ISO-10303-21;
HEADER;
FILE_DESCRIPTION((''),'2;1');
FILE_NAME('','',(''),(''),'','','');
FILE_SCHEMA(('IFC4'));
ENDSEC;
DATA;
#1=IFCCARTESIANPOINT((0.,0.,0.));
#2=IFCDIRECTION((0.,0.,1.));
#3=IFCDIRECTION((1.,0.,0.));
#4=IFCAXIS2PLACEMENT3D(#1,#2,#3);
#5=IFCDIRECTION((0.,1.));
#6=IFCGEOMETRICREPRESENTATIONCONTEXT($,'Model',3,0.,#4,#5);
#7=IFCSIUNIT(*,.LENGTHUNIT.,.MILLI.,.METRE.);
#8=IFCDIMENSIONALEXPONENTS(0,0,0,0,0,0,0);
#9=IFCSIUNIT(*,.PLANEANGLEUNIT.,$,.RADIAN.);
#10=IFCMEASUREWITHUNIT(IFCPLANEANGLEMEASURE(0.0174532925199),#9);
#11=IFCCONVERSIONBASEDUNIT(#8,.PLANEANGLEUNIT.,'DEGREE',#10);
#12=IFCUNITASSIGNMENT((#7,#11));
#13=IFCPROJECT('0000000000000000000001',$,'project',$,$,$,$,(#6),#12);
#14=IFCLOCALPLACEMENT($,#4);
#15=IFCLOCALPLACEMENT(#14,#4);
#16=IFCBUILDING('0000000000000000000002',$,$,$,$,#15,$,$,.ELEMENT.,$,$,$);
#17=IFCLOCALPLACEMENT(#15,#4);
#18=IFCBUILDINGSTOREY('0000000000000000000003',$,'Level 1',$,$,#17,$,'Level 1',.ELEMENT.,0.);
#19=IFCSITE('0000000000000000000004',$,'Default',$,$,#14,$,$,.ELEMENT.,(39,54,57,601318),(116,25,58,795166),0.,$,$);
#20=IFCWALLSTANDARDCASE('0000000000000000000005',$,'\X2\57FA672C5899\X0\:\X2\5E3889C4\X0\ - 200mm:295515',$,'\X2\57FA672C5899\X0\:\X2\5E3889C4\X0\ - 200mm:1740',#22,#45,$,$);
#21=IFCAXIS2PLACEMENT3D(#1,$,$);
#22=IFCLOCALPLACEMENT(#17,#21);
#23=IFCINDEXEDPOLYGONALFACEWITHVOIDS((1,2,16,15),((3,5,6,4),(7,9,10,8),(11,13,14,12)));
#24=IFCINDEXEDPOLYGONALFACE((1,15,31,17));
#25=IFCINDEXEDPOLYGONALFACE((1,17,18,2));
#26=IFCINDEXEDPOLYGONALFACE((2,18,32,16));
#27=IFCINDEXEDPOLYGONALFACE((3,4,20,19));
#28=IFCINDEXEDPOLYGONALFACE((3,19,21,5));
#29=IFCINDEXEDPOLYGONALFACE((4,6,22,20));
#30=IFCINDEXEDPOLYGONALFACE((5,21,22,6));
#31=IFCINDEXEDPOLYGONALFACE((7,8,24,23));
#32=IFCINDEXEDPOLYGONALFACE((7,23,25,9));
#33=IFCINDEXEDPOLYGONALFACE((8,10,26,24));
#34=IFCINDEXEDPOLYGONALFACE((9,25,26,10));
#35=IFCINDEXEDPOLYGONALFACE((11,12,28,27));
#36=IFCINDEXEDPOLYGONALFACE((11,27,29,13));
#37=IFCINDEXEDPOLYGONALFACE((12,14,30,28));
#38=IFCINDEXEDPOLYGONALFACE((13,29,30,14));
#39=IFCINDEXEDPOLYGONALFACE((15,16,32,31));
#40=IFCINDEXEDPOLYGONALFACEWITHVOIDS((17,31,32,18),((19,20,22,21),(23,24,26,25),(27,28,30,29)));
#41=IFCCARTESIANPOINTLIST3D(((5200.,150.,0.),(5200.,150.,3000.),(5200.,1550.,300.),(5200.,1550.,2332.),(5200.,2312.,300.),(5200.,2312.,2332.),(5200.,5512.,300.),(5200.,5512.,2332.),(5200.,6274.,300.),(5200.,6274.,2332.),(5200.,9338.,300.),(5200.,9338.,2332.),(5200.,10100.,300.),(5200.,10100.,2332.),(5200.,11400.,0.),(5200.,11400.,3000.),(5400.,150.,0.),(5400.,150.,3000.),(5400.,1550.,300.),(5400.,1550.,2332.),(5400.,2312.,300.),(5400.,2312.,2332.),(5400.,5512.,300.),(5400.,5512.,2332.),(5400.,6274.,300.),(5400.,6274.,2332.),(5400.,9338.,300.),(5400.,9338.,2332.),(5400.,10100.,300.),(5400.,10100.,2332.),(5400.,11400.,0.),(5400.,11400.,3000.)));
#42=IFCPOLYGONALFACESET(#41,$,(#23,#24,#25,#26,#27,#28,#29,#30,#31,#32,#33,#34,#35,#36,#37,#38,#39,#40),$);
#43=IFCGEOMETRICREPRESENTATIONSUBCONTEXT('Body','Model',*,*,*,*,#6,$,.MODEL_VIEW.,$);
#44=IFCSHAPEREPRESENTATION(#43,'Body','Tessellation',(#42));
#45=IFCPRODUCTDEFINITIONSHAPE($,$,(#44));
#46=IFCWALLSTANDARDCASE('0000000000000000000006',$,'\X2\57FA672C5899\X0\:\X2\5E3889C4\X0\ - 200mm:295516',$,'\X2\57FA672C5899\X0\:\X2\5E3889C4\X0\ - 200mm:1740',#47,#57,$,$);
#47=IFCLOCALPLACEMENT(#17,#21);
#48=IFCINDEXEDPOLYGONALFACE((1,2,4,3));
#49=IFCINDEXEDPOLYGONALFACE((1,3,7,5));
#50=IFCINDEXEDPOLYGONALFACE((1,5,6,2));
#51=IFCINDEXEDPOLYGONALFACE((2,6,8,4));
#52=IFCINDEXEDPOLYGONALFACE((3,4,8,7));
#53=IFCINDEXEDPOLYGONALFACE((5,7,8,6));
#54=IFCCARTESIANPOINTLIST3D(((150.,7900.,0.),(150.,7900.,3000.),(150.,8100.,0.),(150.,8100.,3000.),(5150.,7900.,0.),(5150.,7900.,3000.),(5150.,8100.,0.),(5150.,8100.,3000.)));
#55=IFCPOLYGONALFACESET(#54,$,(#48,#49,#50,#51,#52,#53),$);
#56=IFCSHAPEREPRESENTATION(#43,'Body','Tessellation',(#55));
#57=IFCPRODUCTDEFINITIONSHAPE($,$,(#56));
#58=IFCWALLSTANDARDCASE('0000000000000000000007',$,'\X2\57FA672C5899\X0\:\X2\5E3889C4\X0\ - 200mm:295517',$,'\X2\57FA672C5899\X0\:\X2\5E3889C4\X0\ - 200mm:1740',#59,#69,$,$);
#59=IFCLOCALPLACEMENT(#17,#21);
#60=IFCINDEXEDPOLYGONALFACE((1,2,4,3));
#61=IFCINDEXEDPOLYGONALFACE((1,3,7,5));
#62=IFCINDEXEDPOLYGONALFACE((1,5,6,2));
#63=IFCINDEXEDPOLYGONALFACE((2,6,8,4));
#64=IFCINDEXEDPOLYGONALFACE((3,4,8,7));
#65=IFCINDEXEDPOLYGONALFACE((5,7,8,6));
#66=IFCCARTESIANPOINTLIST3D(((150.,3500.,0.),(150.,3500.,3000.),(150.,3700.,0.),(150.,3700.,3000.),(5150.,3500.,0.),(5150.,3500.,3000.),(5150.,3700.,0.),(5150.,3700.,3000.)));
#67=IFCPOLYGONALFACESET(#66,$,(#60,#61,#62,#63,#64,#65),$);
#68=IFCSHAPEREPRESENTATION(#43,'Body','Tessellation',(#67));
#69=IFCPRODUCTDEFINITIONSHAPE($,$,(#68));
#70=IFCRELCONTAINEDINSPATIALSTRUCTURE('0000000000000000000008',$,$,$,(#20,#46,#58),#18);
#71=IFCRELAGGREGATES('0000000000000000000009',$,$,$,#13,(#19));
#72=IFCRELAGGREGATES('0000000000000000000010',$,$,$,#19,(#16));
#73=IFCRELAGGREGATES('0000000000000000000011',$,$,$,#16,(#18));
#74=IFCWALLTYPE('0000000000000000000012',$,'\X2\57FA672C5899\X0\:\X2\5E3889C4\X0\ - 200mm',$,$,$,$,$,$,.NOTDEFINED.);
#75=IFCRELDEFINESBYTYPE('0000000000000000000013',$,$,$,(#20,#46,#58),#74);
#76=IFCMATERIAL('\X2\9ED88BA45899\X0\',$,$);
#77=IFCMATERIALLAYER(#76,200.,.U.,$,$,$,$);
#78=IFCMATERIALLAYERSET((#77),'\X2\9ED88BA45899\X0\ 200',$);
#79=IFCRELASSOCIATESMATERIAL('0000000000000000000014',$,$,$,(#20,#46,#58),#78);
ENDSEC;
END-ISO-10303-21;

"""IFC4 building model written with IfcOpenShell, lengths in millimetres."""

from ifc_helpers import new_model, entity, si_unit, converted_unit, direction, frame, origin_with_axes, place, context, subcontext, project, spatial, polyline, outline, extrude, material, layer, layer_set, layer_usage, type_object, element, save


model = new_model("IFC4")

# Units and contexts
model_context = context("Model", 3, precision=0.0, world=origin_with_axes(), true_north=direction((0.0, 1.0)))
body_context = subcontext(model_context, "Body", "Model", "MODEL_VIEW")
ifc_project = project(units=[si_unit("LENGTHUNIT", "METRE", prefix="MILLI"), converted_unit("PLANEANGLEUNIT", "DEGREE", entity("IfcPlaneAngleMeasure", 0.0174532925199), si_unit("PLANEANGLEUNIT", "RADIAN"), dimensions=[0, 0, 0, 0, 0, 0, 0])], contexts=[model_context])

# Site, building, storey
site_placement = place(None, origin_with_axes())
site = spatial("IfcSite", under=ifc_project, at=site_placement, Name="Default", CompositionType="ELEMENT", RefLatitude=(39, 54, 57, 601318), RefLongitude=(116, 25, 58, 795166), RefElevation=0.0)
building_placement = place(site_placement, origin_with_axes())
building = spatial("IfcBuilding", under=site, at=building_placement, CompositionType="ELEMENT")
storey_placement = place(building_placement, origin_with_axes())
storey = spatial("IfcBuildingStorey", under=building, at=storey_placement, Name="Level 1", LongName="Level 1", CompositionType="ELEMENT", Elevation=0.0)

# Shared definitions
ifc_material_1 = material(Name="默认墙")
ifc_layer_1 = layer(ifc_material_1, 200.0, ventilated="UNKNOWN")
ifc_layer_set_1 = layer_set([ifc_layer_1], Name="默认墙 200")
wall_type = type_object("IfcWallType", Name="基本墙:常规 - 200mm", PredefinedType="NOTDEFINED")

# Wall, openings
ifc_layer_usage_1 = layer_usage(ifc_layer_set_1, "AXIS2", "POSITIVE", -100.0)
wall_1_placement = place(storey_placement, frame((5300.0, 11500.0, 0.0), z_axis=(0.0, 0.0, 1.0), x_axis=(0.0, -1.0, 0.0)))
wall_1 = element("IfcWallStandardCase", 1, at=wall_1_placement, inside=storey, type_object=wall_type, material=ifc_layer_usage_1, Name="基本墙:常规 - 200mm:295515", ObjectType="基本墙:常规 - 200mm:1740", context=body_context, shape_type="SweptSolid", body=[
    extrude(outline(polyline([(100.0, -100.0), (11350.0, -100.0), (11350.0, 100.0), (100.0, 100.0), (100.0, -100.0)])), origin_with_axes(), (0.0, 0.0, 1.0), 3000.0),
])
opening_1_placement = place(wall_1_placement, frame((1781.0, 0.0, 300.0), z_axis=(0.0, 0.0, 1.0), x_axis=(1.0, 0.0, 0.0)))
element("IfcOpeningElement", 2, at=opening_1_placement, cuts=wall_1, context=body_context, shape_type="SweptSolid", body=[
    extrude(outline(polyline([(-381.0, -2032.0), (381.0, -2032.0), (381.0, 0.0), (-381.0, 0.0), (-381.0, -2032.0)])), frame((0.0, -100.0, 0.0), z_axis=(0.0, 1.0, 0.0), x_axis=(1.0, 0.0, 0.0)), (0.0, 0.0, 1.0), 200.0),
])
opening_2_placement = place(wall_1_placement, frame((9569.0, 0.0, 300.0), z_axis=(0.0, 0.0, 1.0), x_axis=(1.0, 0.0, 0.0)))
element("IfcOpeningElement", 3, at=opening_2_placement, cuts=wall_1, context=body_context, shape_type="SweptSolid", body=[
    extrude(outline(polyline([(-381.0, -2032.0), (381.0, -2032.0), (381.0, 0.0), (-381.0, 0.0), (-381.0, -2032.0)])), frame((0.0, -100.0, 0.0), z_axis=(0.0, 1.0, 0.0), x_axis=(1.0, 0.0, 0.0)), (0.0, 0.0, 1.0), 200.0),
])
opening_3_placement = place(wall_1_placement, frame((5607.0, 0.0, 300.0), z_axis=(0.0, 0.0, 1.0), x_axis=(1.0, 0.0, 0.0)))
element("IfcOpeningElement", 4, at=opening_3_placement, cuts=wall_1, context=body_context, shape_type="SweptSolid", body=[
    extrude(outline(polyline([(-381.0, -2032.0), (381.0, -2032.0), (381.0, 0.0), (-381.0, 0.0), (-381.0, -2032.0)])), frame((0.0, -100.0, 0.0), z_axis=(0.0, 1.0, 0.0), x_axis=(1.0, 0.0, 0.0)), (0.0, 0.0, 1.0), 200.0),
])

# Walls
ifc_layer_usage_2 = layer_usage(ifc_layer_set_1, "AXIS2", "POSITIVE", -100.0)
wall_2_placement = place(storey_placement, frame((150.0, 8000.0, 0.0), z_axis=(0.0, 0.0, 1.0), x_axis=(1.0, 0.0, 0.0)))
element("IfcWallStandardCase", 5, at=wall_2_placement, inside=storey, type_object=wall_type, material=ifc_layer_usage_2, Name="基本墙:常规 - 200mm:295516", ObjectType="基本墙:常规 - 200mm:1740", context=body_context, shape_type="SweptSolid", body=[
    extrude(outline(polyline([(0.0, -100.0), (5000.0, -100.0), (5000.0, 100.0), (0.0, 100.0), (0.0, -100.0)])), origin_with_axes(), (0.0, 0.0, 1.0), 3000.0),
])
ifc_layer_usage_3 = layer_usage(ifc_layer_set_1, "AXIS2", "POSITIVE", -100.0)
wall_3_placement = place(storey_placement, frame((150.0, 3600.0, 0.0), z_axis=(0.0, 0.0, 1.0), x_axis=(1.0, 0.0, 0.0)))
element("IfcWallStandardCase", 6, at=wall_3_placement, inside=storey, type_object=wall_type, material=ifc_layer_usage_3, Name="基本墙:常规 - 200mm:295517", ObjectType="基本墙:常规 - 200mm:1740", context=body_context, shape_type="SweptSolid", body=[
    extrude(outline(polyline([(0.0, -100.0), (5000.0, -100.0), (5000.0, 100.0), (0.0, 100.0), (0.0, -100.0)])), origin_with_axes(), (0.0, 0.0, 1.0), 3000.0),
])

save(model, "model.ifc")
